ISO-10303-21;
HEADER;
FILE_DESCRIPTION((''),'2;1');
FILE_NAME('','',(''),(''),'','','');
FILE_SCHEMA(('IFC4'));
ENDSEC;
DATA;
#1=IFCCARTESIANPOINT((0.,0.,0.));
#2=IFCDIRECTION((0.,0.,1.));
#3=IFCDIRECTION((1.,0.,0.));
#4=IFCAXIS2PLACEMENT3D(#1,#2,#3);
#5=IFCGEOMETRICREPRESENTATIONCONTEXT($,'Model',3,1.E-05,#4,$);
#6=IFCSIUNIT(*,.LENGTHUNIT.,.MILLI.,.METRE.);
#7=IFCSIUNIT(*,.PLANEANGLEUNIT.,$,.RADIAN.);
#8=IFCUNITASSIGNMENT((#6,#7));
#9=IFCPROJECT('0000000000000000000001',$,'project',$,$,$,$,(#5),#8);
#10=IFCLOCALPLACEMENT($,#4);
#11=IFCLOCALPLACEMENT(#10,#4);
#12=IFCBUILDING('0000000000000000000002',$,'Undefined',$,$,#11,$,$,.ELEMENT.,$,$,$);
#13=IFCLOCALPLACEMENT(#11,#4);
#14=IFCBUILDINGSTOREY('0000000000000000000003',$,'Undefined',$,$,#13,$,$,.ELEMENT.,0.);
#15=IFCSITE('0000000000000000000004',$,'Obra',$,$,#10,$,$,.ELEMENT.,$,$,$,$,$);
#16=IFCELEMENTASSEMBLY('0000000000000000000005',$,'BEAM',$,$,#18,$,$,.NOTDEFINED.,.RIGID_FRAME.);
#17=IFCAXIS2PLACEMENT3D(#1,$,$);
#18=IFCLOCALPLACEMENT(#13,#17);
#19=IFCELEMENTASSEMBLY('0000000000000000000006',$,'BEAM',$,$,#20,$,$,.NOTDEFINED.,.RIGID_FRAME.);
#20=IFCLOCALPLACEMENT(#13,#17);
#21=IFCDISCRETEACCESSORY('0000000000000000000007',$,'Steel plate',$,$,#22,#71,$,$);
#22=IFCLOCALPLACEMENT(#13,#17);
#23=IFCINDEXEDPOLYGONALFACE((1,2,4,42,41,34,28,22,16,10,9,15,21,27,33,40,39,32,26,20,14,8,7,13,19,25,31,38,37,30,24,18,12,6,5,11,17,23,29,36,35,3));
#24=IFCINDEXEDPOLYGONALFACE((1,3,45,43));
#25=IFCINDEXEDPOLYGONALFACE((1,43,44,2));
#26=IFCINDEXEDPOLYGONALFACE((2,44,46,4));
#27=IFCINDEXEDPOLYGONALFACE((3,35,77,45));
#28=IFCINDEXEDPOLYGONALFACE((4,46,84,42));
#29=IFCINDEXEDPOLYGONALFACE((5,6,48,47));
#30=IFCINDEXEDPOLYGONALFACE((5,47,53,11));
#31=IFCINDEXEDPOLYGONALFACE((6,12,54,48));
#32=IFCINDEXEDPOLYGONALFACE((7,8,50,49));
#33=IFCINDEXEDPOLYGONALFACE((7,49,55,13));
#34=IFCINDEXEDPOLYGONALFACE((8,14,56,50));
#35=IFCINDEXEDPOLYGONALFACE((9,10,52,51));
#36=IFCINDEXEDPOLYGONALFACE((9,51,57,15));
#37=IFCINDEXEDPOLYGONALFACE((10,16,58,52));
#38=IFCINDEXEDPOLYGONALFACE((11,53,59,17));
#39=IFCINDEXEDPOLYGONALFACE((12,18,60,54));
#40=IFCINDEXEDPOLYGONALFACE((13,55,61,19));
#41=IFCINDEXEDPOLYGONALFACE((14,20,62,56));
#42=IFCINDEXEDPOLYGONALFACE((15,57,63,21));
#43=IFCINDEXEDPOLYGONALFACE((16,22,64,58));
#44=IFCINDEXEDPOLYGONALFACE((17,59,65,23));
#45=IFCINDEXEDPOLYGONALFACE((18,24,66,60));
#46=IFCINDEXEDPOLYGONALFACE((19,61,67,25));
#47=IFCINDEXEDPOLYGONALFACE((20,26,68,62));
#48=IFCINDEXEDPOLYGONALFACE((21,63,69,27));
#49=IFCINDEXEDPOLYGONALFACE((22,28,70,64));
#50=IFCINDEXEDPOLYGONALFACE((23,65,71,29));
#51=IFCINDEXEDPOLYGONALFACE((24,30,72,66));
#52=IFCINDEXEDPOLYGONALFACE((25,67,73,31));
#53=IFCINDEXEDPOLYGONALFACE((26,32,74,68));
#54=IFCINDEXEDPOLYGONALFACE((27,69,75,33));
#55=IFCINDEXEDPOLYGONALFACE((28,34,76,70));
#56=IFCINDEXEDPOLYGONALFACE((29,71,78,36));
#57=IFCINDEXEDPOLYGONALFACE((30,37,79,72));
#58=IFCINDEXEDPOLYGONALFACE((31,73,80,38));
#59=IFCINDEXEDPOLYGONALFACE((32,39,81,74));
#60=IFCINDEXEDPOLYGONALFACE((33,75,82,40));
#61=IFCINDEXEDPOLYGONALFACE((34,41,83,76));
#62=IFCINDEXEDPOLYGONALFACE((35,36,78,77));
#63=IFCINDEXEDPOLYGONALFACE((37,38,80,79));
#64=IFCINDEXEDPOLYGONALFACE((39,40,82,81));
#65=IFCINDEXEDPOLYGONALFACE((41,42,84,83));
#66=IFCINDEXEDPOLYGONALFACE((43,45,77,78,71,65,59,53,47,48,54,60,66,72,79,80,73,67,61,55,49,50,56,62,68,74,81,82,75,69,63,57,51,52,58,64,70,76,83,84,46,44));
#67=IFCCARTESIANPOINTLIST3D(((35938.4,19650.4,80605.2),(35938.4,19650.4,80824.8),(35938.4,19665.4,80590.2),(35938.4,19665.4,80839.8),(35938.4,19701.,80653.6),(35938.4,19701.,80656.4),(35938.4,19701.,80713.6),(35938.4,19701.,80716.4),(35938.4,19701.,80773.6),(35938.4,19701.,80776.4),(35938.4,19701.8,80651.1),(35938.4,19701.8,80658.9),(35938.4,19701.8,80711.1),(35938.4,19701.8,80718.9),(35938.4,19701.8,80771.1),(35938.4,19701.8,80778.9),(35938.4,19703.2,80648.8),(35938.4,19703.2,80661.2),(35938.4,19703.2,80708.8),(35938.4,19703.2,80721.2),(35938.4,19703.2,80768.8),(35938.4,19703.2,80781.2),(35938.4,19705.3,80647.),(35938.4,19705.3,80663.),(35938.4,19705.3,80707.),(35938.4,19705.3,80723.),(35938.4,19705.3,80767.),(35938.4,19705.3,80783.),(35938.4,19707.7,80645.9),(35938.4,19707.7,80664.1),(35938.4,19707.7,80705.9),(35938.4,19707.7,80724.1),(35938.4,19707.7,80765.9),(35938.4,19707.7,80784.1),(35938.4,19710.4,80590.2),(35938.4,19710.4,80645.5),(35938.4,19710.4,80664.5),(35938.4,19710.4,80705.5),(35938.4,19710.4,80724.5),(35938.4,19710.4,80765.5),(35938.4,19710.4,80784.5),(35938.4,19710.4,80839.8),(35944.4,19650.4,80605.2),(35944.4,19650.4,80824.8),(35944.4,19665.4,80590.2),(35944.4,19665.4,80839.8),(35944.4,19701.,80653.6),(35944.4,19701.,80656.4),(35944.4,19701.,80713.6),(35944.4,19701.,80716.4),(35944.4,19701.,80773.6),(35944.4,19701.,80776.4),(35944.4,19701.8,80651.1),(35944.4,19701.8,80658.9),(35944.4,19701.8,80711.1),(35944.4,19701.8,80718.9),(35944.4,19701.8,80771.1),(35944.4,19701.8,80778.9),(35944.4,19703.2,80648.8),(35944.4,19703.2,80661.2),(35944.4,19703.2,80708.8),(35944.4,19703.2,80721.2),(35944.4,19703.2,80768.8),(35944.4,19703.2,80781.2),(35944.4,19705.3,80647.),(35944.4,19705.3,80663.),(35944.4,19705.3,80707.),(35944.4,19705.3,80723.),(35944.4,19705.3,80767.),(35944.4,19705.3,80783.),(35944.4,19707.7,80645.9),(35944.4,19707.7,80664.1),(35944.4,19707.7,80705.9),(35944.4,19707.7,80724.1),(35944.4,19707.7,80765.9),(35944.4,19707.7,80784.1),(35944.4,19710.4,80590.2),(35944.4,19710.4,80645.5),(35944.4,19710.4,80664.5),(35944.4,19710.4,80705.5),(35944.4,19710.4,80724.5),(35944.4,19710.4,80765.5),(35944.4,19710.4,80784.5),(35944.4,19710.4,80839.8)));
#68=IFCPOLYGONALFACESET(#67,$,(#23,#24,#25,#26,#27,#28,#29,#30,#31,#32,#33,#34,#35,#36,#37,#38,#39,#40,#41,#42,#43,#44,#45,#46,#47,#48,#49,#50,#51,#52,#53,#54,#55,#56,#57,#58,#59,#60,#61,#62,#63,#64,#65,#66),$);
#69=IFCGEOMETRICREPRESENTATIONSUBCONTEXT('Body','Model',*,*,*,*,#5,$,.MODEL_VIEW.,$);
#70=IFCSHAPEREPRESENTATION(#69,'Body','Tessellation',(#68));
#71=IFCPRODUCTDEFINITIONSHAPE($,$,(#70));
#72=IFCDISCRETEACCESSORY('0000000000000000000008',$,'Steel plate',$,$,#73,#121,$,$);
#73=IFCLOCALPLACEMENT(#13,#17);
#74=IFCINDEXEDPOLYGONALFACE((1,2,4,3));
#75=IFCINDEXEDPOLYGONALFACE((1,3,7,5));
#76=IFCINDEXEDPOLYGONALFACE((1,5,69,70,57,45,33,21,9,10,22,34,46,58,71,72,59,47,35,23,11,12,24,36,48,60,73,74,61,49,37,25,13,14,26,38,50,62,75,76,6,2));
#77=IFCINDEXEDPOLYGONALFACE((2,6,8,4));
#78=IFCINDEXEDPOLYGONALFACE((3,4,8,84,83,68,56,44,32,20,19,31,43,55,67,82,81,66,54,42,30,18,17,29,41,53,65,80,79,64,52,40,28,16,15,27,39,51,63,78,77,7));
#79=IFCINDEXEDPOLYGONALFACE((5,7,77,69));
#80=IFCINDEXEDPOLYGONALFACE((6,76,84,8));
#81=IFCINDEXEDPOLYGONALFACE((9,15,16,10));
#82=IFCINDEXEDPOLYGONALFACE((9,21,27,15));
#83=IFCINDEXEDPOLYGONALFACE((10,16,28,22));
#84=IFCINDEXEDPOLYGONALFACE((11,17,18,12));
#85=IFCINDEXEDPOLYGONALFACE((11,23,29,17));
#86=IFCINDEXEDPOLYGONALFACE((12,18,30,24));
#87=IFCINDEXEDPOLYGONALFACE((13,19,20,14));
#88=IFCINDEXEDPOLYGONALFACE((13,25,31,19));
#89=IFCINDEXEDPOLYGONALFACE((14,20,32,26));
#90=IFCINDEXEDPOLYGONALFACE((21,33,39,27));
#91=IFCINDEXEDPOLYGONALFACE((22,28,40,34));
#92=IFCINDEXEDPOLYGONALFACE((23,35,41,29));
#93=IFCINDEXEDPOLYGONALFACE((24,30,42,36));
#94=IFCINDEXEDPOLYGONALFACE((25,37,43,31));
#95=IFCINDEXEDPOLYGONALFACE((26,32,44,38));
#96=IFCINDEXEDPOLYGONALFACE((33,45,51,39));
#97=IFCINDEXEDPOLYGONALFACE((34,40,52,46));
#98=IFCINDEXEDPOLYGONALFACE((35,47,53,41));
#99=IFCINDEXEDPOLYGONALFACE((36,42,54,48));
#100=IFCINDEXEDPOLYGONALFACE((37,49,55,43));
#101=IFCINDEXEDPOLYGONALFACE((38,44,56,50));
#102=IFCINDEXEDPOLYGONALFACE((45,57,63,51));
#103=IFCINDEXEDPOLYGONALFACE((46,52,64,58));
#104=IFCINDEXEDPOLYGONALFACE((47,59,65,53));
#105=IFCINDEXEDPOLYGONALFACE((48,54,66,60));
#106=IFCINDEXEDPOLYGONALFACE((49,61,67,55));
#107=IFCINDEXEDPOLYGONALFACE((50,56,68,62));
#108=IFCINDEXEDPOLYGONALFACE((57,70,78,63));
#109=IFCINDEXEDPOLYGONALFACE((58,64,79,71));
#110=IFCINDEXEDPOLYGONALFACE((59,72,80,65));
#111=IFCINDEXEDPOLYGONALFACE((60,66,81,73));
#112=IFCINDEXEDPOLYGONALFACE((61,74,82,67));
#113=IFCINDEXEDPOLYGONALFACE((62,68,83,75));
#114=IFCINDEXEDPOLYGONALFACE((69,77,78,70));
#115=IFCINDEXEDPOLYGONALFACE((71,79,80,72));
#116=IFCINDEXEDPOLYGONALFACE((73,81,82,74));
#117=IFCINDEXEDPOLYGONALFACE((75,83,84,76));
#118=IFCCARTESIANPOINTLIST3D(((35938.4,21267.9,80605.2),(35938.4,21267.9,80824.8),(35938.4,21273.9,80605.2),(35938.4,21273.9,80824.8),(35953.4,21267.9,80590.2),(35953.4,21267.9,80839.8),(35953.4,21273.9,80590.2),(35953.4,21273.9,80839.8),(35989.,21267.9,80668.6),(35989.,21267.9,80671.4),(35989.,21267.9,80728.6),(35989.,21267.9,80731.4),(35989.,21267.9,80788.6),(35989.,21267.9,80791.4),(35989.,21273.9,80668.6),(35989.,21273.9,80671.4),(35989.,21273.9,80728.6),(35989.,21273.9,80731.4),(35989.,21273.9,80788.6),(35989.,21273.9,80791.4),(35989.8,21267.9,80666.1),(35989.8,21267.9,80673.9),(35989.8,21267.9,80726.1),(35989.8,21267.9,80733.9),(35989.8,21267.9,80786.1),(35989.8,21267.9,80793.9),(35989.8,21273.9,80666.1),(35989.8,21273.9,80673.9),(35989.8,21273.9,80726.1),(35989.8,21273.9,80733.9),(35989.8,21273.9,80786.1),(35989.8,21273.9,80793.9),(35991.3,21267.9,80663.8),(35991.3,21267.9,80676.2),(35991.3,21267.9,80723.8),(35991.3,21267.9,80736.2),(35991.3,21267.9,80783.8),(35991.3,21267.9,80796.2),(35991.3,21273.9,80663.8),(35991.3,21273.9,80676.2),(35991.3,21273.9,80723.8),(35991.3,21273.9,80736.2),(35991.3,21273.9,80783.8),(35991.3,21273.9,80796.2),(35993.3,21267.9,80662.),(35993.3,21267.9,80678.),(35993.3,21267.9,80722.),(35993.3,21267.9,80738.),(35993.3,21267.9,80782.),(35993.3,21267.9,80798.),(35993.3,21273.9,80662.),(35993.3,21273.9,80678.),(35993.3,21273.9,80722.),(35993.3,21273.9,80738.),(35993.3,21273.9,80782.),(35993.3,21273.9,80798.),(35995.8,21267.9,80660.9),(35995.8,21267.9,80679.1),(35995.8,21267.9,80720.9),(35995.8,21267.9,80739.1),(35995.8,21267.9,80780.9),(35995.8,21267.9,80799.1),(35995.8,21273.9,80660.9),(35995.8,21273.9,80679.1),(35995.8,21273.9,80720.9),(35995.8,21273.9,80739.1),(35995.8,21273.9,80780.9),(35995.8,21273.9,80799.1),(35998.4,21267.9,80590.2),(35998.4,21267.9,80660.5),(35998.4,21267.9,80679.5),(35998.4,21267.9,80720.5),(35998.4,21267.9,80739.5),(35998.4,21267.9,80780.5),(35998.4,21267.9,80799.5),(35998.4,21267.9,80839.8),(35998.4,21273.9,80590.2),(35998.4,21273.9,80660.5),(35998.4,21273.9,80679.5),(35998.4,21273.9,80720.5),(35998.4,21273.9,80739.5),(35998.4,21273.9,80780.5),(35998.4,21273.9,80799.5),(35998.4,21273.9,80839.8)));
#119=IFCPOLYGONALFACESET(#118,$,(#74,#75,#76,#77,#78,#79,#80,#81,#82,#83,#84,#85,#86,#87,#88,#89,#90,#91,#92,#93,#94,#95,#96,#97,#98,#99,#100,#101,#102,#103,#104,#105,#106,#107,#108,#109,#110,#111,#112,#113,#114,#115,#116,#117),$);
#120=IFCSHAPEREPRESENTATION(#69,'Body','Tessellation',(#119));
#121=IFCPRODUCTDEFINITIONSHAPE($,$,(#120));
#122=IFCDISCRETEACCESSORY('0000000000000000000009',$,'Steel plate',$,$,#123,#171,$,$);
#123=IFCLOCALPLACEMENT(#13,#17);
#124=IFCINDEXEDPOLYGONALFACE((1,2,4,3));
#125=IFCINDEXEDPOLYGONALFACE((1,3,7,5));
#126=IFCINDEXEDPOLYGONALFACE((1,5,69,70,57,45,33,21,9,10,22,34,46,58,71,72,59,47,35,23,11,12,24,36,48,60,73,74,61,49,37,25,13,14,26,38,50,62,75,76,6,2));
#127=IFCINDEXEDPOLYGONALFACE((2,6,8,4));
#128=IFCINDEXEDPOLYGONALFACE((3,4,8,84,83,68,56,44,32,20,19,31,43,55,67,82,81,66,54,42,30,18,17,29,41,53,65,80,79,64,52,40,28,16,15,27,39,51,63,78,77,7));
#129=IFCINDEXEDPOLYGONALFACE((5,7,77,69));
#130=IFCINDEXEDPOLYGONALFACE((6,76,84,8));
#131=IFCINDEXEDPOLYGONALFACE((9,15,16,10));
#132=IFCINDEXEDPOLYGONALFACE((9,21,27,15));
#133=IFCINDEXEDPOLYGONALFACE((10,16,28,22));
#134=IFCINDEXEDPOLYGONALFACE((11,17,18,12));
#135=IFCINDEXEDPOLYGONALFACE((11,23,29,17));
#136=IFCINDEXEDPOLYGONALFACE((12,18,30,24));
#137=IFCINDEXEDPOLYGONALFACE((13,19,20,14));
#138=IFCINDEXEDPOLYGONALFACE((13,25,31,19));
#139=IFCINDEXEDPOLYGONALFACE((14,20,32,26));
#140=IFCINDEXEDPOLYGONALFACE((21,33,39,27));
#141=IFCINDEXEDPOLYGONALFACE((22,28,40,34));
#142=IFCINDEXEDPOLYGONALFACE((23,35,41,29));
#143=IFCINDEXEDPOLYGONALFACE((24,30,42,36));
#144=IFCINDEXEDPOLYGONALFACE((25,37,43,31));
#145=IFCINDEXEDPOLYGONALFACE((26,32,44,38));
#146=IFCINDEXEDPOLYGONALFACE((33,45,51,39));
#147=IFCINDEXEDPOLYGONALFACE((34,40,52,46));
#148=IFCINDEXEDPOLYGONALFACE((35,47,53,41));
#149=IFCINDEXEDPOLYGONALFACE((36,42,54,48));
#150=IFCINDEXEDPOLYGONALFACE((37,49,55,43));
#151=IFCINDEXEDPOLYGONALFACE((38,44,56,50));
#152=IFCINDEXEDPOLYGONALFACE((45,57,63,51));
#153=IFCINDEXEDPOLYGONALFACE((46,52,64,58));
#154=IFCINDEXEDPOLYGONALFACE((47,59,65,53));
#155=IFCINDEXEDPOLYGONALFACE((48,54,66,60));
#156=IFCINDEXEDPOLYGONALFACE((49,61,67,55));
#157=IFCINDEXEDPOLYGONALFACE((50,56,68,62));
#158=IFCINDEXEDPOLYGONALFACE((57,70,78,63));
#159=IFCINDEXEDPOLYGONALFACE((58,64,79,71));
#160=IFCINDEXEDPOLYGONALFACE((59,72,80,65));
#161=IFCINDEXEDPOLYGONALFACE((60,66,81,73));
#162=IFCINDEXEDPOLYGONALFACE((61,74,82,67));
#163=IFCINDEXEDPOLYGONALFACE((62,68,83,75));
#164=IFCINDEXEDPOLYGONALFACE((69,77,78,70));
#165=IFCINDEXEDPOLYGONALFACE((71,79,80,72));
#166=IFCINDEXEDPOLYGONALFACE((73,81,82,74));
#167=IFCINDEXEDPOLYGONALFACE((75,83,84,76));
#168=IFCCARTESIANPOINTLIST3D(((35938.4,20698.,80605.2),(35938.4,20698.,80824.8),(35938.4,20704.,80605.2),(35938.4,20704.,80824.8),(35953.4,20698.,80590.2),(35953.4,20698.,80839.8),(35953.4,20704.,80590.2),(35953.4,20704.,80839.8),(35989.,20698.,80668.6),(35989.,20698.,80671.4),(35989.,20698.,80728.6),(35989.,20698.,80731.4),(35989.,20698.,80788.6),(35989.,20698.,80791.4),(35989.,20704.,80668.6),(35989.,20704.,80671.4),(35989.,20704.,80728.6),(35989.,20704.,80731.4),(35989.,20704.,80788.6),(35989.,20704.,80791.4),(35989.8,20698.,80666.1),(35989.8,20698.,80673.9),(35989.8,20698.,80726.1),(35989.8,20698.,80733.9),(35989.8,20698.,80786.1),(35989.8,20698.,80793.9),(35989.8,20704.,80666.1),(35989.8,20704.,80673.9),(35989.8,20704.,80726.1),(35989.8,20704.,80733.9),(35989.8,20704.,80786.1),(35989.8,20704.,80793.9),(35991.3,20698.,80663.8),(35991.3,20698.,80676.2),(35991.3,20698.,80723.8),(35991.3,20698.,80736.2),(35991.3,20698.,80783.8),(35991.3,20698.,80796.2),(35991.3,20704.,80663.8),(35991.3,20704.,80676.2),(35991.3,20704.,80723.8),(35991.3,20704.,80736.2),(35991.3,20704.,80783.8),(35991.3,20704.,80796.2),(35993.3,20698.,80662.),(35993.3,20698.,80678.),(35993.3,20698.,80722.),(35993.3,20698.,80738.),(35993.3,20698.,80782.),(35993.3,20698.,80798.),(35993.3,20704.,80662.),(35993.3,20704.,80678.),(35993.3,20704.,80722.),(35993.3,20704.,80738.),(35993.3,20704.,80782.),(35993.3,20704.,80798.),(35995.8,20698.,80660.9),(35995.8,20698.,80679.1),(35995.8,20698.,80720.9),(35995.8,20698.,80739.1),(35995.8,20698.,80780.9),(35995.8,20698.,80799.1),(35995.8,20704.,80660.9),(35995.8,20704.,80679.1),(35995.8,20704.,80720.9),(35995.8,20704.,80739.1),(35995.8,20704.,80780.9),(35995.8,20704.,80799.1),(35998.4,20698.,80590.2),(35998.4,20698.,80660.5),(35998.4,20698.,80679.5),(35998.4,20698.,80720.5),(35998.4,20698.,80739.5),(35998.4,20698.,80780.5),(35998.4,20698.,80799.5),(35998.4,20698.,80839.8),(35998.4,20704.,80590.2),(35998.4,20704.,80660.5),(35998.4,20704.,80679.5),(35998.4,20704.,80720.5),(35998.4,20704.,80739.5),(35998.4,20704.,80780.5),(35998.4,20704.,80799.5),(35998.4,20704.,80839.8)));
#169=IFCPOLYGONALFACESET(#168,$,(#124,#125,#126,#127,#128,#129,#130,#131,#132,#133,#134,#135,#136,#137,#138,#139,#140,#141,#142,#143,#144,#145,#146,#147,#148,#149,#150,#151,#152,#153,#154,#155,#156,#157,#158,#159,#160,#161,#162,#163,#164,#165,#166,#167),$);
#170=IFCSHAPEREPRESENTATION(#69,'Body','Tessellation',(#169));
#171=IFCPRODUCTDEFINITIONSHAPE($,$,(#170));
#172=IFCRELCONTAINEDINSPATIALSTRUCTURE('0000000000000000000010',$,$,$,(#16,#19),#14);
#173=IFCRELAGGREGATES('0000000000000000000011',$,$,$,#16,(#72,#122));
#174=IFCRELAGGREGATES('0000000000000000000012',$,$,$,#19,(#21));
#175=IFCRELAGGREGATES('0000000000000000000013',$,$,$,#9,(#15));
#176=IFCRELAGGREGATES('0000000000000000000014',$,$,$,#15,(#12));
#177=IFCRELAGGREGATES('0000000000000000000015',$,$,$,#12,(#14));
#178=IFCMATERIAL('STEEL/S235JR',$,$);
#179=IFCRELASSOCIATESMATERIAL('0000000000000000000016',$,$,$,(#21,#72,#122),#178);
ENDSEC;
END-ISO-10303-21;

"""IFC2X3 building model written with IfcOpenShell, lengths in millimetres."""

from ifc_helpers import new_model, si_unit, frame, origin_with_axes, origin_2d_with_axis, place, context, subcontext, project, spatial, polyline, circle, outline, extrude, source, transform, mapped, material, element, aggregate, save


model = new_model("IFC2X3")

# Units and contexts
model_context = context("Model", 3, precision=1e-05, world=origin_with_axes())
body_context = subcontext(model_context, "Body", "Model", "MODEL_VIEW")
ifc_project = project(units=[si_unit("LENGTHUNIT", "METRE", prefix="MILLI"), si_unit("PLANEANGLEUNIT", "RADIAN")], contexts=[model_context])

# Site, building, storey
site_placement = place(None, origin_with_axes())
site = spatial("IfcSite", under=ifc_project, at=site_placement, Name="Obra", CompositionType="ELEMENT")
building_placement = place(site_placement, origin_with_axes())
building = spatial("IfcBuilding", under=site, at=building_placement, Name="Undefined", CompositionType="ELEMENT")
storey_placement = place(building_placement, origin_with_axes())
storey = spatial("IfcBuildingStorey", under=building, at=storey_placement, Name="Undefined", CompositionType="ELEMENT", Elevation=0.0)

# Element assembly
ifc_material_1 = material(Name="STEEL/S235JR")
assembly_1_placement = place(storey_placement, origin_with_axes())
assembly_1 = element("IfcElementAssembly", 1, at=assembly_1_placement, inside=storey, Name="BEAM", AssemblyPlace="NOTDEFINED", PredefinedType="RIGID_FRAME")

# Element assembly, discrete accessory, opening
assembly_2_placement = place(storey_placement, origin_with_axes())
assembly_2 = element("IfcElementAssembly", 2, at=assembly_2_placement, inside=storey, Name="BEAM", AssemblyPlace="NOTDEFINED", PredefinedType="RIGID_FRAME")
discrete_accessory_1_placement = place(assembly_2_placement, frame((35941.4, 19710.4, 80590.2), z_axis=(-1.0, 0.0, 0.0), x_axis=(0.0, -1.0, 0.0)))
discrete_accessory_1 = element("IfcDiscreteAccessory", 3, at=discrete_accessory_1_placement, material=ifc_material_1, Name="Steel plate", context=body_context, shape_type="SweptSolid", body=[
    extrude(outline(polyline([(0.0, 0.0), (45.0, 0.0), (60.0, 15.0), (60.0, 234.6), (45.0, 249.6), (0.0, 249.6), (0.0, 0.0)])), frame((0.0, 0.0, -3.0), z_axis=(0.0, 0.0, 1.0), x_axis=(1.0, 0.0, 0.0)), (0.0, 0.0, 1.0), 6.0),
])
shared_shape_1 = source(origin_with_axes(), body_context, "Body", "SweptSolid", [
    extrude(circle(Radius=9.5, at=origin_2d_with_axis()), frame((0.0, -9.4, 0.0), z_axis=(0.0, 1.0, 0.0), x_axis=(1.0, 0.0, 0.0)), (0.0, 0.0, 1.0), 6.2),
])
opening_1_placement = place(assembly_2_placement, frame((35935.1, 19660.4, 80850.0), z_axis=(0.0, 1.0, 0.0), x_axis=(0.0, 0.0, -1.0)))
element("IfcOpeningElement", 4, at=opening_1_placement, cuts=discrete_accessory_1, ObjectType="Opening", context=body_context, shape_type="MappedRepresentation", body=[
    mapped(shared_shape_1, transform((75.0, 0.0, 50.0))),
    mapped(shared_shape_1, transform((135.0, 0.0, 50.0))),
    mapped(shared_shape_1, transform((195.0, 0.0, 50.0))),
])

# Discrete accessories, openings
discrete_accessory_2_placement = place(assembly_1_placement, frame((35998.4, 21270.9, 80590.2), z_axis=(0.0, 1.0, 0.0), x_axis=(-1.0, 0.0, 0.0)))
discrete_accessory_2 = element("IfcDiscreteAccessory", 5, at=discrete_accessory_2_placement, material=ifc_material_1, Name="Steel plate", context=body_context, shape_type="SweptSolid", body=[
    extrude(outline(polyline([(0.0, 0.0), (45.0, 0.0), (60.0, 15.0), (60.0, 234.6), (45.0, 249.6), (0.0, 249.6), (0.0, 0.0)])), frame((0.0, 0.0, -3.0), z_axis=(0.0, 0.0, 1.0), x_axis=(1.0, 0.0, 0.0)), (0.0, 0.0, 1.0), 6.0),
])
shared_shape_2 = source(origin_with_axes(), body_context, "Body", "SweptSolid", [
    extrude(circle(Radius=9.5, at=origin_2d_with_axis()), frame((0.0, -9.2, 0.0), z_axis=(0.0, 1.0, 0.0), x_axis=(1.0, 0.0, 0.0)), (0.0, 0.0, 1.0), 6.2),
])
opening_2_placement = place(assembly_1_placement, frame((35948.4, 21277.0, 80850.0), z_axis=(1.0, 0.0, 0.0), x_axis=(0.0, 0.0, -1.0)))
element("IfcOpeningElement", 6, at=opening_2_placement, cuts=discrete_accessory_2, ObjectType="Opening", context=body_context, shape_type="MappedRepresentation", body=[
    mapped(shared_shape_2, transform((60.0, 0.0, 50.0))),
    mapped(shared_shape_2, transform((120.0, 0.0, 50.0))),
    mapped(shared_shape_2, transform((180.0, 0.0, 50.0))),
])
discrete_accessory_3_placement = place(assembly_1_placement, frame((35998.4, 20701.0, 80590.2), z_axis=(0.0, 1.0, 0.0), x_axis=(-1.0, 0.0, 0.0)))
discrete_accessory_3 = element("IfcDiscreteAccessory", 7, at=discrete_accessory_3_placement, material=ifc_material_1, Name="Steel plate", context=body_context, shape_type="SweptSolid", body=[
    extrude(outline(polyline([(0.0, 0.0), (45.0, 0.0), (60.0, 15.0), (60.0, 234.6), (45.0, 249.6), (0.0, 249.6), (0.0, 0.0)])), frame((0.0, 0.0, -3.0), z_axis=(0.0, 0.0, 1.0), x_axis=(1.0, 0.0, 0.0)), (0.0, 0.0, 1.0), 6.0),
])
opening_3_placement = place(assembly_1_placement, frame((35948.4, 20707.1, 80850.0), z_axis=(1.0, 0.0, 0.0), x_axis=(0.0, 0.0, -1.0)))
element("IfcOpeningElement", 8, at=opening_3_placement, cuts=discrete_accessory_3, ObjectType="Opening", context=body_context, shape_type="MappedRepresentation", body=[
    mapped(shared_shape_2, transform((60.0, 0.0, 50.0))),
    mapped(shared_shape_2, transform((120.0, 0.0, 50.0))),
    mapped(shared_shape_2, transform((180.0, 0.0, 50.0))),
])
aggregate(assembly_1, [discrete_accessory_2, discrete_accessory_3])
aggregate(assembly_2, [discrete_accessory_1])

save(model, "model.ifc")
